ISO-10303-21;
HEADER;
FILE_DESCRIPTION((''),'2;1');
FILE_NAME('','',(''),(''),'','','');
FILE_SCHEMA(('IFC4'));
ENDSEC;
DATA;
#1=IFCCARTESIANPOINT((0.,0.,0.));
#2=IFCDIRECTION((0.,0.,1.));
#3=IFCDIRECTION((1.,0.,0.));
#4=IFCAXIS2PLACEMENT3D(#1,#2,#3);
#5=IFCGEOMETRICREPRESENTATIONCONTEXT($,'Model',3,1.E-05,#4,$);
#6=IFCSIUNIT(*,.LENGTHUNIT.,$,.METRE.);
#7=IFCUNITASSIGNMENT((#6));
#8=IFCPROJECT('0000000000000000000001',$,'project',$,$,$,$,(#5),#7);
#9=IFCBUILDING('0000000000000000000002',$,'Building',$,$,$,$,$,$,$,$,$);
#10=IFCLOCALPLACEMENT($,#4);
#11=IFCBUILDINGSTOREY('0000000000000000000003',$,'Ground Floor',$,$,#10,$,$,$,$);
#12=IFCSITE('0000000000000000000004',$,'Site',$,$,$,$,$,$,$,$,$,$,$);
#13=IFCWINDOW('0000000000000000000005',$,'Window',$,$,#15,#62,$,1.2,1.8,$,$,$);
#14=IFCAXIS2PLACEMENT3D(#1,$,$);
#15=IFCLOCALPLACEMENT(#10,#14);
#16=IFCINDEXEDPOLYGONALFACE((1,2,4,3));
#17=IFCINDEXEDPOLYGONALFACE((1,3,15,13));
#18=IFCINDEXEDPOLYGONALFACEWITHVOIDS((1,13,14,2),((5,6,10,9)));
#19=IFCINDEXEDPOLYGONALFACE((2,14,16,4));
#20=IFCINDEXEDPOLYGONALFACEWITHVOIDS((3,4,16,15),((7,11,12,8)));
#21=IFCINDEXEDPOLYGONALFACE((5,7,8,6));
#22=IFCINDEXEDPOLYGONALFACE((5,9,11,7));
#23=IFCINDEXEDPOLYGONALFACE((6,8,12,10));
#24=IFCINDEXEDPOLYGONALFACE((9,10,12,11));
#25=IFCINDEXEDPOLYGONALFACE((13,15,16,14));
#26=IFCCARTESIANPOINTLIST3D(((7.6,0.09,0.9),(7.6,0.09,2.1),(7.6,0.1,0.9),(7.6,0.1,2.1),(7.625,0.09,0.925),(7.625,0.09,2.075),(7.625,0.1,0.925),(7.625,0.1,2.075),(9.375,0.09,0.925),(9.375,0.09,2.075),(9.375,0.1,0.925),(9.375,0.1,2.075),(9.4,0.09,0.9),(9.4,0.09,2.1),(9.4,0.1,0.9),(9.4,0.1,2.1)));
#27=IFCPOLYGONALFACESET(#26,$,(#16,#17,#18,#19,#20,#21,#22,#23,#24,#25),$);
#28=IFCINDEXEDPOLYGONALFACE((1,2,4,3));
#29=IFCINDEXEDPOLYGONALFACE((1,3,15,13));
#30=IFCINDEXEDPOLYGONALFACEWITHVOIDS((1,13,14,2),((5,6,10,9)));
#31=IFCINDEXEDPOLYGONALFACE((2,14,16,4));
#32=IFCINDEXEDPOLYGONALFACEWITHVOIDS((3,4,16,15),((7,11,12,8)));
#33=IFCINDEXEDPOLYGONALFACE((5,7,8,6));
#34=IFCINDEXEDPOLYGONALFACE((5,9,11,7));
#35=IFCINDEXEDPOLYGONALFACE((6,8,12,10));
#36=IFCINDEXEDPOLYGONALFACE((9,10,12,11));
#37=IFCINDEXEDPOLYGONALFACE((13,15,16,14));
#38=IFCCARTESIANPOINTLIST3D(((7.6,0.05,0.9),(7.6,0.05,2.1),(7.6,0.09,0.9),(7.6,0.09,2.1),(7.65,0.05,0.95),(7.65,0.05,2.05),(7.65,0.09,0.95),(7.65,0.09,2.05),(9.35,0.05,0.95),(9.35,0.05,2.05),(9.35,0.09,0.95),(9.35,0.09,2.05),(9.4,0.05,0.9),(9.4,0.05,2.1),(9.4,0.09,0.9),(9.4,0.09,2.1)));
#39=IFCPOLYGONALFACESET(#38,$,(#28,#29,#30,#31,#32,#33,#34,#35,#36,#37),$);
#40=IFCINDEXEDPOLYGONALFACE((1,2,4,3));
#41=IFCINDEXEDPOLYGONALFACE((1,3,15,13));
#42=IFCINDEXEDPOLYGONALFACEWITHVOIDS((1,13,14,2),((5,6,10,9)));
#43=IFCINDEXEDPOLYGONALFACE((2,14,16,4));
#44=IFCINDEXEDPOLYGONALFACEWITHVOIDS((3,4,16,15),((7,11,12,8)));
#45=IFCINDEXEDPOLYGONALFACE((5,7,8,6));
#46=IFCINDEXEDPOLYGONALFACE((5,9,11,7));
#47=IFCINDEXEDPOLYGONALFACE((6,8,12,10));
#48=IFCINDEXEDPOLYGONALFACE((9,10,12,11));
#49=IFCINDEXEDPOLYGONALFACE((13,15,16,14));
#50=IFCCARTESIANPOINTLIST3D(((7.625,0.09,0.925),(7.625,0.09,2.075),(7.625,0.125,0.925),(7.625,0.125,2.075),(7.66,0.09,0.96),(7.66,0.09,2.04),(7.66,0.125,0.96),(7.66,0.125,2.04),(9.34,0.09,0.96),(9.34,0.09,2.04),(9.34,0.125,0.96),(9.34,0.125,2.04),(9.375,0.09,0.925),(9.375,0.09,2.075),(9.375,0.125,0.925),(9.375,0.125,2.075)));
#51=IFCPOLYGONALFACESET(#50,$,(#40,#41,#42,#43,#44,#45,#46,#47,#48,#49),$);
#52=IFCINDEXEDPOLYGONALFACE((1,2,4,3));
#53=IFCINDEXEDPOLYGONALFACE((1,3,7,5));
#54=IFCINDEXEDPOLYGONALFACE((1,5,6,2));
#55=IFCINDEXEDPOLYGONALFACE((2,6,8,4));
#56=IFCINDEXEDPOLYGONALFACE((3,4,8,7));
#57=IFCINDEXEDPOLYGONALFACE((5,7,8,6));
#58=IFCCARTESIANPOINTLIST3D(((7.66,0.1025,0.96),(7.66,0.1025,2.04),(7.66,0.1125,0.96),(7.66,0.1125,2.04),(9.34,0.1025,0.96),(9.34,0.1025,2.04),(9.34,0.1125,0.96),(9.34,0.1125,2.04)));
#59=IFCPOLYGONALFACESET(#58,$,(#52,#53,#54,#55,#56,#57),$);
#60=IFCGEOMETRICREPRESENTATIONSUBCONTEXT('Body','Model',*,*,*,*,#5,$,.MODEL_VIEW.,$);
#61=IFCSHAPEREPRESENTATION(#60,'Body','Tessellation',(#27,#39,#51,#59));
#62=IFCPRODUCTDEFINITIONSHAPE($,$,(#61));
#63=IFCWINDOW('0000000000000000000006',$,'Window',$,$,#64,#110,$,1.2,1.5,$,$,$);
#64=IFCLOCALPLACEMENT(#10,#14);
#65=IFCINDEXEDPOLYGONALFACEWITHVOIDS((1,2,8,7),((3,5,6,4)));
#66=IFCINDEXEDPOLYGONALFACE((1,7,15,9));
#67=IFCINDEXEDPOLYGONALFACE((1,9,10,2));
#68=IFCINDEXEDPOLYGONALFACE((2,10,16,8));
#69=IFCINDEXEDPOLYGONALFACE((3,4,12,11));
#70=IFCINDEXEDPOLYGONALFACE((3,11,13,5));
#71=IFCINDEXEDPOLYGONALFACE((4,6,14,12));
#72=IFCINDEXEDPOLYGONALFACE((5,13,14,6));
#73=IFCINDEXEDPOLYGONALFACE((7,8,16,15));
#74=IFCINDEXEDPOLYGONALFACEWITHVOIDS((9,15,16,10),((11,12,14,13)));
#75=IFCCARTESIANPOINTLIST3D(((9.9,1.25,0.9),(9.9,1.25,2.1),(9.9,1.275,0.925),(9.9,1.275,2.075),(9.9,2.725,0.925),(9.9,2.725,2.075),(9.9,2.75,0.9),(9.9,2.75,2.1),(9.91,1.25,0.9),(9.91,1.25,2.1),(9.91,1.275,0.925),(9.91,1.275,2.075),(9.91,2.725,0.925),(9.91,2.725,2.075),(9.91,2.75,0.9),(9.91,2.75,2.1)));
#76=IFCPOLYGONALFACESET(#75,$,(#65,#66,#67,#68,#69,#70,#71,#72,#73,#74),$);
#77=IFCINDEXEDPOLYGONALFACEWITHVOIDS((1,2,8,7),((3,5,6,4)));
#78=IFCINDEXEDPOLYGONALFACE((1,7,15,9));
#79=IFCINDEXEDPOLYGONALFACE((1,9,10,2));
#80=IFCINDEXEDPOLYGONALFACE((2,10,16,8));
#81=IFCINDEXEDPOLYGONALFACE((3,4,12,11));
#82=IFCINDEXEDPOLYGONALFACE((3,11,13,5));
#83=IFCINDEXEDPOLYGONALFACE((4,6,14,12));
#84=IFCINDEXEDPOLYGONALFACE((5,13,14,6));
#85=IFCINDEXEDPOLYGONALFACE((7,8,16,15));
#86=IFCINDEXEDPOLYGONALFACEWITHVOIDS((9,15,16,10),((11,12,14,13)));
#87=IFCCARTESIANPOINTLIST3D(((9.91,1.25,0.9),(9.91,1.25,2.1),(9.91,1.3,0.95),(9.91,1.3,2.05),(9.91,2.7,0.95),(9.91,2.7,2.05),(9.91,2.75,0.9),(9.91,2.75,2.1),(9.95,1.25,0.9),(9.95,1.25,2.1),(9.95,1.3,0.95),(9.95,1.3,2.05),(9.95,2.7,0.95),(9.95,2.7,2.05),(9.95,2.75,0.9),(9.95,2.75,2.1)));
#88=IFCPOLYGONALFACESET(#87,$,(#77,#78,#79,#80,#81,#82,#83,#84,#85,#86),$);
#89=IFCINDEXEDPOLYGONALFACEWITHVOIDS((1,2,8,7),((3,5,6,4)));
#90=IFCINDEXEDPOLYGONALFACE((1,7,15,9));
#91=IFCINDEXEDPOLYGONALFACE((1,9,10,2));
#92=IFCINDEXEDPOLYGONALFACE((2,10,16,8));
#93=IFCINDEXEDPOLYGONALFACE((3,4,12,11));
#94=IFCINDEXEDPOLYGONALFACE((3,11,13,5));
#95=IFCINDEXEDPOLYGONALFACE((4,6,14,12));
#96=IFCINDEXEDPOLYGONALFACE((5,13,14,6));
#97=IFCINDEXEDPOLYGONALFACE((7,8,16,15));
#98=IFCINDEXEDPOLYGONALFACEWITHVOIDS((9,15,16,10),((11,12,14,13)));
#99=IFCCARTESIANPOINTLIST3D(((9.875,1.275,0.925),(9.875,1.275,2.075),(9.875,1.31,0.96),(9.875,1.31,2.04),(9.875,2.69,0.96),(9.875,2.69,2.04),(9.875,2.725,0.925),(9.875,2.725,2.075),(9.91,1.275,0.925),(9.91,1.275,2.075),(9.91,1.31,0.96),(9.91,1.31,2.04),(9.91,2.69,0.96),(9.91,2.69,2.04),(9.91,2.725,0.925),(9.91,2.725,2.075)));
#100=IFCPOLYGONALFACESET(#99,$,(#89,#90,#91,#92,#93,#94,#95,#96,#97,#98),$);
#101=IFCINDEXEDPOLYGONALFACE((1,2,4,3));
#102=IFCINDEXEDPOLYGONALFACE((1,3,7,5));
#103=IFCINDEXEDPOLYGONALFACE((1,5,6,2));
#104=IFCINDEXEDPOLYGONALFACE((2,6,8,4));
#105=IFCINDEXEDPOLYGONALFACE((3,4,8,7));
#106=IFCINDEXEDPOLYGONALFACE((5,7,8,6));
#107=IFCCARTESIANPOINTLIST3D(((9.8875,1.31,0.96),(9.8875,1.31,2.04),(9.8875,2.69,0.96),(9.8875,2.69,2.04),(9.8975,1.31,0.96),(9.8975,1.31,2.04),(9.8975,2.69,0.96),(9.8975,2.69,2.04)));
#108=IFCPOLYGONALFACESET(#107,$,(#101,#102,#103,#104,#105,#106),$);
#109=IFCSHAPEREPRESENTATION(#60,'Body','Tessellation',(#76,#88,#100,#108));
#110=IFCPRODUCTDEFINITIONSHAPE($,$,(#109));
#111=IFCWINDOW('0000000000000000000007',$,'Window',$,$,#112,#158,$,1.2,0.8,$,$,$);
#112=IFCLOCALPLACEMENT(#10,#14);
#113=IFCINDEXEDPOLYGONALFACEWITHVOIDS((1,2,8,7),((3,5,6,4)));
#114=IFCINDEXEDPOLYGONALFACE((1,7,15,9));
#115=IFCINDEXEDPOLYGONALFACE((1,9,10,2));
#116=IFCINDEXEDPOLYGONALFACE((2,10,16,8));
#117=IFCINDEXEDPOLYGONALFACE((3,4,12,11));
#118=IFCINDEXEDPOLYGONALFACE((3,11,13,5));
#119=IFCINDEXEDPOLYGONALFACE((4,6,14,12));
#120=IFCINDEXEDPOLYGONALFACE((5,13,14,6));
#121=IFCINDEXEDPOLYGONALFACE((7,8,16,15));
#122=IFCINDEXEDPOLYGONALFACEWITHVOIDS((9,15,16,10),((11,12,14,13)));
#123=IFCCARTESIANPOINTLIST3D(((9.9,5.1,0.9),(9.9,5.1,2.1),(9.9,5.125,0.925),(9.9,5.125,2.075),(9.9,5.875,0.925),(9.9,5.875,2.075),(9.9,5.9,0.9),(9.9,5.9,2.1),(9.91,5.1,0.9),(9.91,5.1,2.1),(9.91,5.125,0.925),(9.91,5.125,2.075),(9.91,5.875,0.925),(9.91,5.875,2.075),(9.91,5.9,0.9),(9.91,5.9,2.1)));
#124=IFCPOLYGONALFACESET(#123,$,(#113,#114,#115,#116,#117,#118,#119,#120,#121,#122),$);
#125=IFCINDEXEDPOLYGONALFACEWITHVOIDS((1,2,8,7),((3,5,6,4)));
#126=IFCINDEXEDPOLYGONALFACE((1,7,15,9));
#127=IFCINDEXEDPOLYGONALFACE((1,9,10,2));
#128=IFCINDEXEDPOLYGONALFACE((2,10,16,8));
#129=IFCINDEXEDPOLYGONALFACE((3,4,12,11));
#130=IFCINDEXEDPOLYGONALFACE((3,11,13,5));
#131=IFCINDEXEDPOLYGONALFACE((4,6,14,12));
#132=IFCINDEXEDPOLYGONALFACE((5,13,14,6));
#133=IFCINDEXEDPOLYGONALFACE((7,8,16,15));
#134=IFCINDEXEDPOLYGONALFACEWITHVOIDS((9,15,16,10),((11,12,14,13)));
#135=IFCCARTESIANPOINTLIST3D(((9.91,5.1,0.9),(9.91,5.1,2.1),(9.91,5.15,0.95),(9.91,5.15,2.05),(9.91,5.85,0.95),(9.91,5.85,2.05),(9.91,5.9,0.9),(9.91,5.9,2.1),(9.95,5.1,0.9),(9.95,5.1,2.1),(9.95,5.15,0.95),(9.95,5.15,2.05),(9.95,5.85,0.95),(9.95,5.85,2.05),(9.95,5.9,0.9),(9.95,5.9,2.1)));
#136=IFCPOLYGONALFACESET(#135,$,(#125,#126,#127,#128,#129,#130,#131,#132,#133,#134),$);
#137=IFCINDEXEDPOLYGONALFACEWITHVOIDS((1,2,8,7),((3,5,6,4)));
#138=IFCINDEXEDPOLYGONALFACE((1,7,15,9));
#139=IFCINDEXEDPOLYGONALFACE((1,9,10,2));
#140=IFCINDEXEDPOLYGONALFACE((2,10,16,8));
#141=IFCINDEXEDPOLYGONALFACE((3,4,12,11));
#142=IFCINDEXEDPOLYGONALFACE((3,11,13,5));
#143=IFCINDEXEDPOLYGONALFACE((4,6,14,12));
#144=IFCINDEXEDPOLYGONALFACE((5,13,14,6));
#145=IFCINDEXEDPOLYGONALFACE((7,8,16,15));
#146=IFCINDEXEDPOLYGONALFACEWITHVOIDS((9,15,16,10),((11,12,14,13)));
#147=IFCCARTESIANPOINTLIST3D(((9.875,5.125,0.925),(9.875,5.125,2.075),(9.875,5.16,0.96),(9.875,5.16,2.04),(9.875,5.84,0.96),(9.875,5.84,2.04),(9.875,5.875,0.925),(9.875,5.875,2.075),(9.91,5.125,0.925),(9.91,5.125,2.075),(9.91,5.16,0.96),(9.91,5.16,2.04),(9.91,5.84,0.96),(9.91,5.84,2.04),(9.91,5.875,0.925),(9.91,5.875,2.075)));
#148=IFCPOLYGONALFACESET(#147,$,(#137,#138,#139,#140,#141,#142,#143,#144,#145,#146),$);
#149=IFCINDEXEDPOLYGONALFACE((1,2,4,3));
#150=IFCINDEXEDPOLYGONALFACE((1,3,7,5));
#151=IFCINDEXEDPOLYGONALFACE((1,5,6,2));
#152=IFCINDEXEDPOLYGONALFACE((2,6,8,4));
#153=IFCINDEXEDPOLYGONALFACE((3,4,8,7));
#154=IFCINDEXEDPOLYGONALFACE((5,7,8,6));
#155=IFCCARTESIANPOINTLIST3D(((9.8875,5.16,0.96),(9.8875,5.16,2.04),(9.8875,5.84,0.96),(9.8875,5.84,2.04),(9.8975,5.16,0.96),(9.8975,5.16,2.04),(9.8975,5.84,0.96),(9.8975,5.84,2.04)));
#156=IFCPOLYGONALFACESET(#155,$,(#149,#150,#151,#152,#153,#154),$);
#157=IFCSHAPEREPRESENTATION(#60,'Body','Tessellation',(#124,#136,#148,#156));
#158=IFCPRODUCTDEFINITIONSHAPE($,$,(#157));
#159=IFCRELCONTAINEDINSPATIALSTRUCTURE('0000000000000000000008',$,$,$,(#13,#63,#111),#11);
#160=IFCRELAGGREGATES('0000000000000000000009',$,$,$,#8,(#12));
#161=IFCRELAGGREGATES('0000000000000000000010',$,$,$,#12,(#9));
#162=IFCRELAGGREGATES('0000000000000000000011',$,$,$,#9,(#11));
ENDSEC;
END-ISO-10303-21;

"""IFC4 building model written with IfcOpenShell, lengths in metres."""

from ifc_helpers import new_model, si_unit, frame, origin_with_axes, place, context, subcontext, project, spatial, line, indexed_curve, outline, extrude, element, save


model = new_model("IFC4")

# Units and contexts
model_context = context("Model", 3, precision=1e-05, world=origin_with_axes())
body_context = subcontext(model_context, "Body", "Model", "MODEL_VIEW")
ifc_project = project(units=[si_unit("LENGTHUNIT", "METRE")], contexts=[model_context])

# Site, building, storey
site = spatial("IfcSite", under=ifc_project, Name="Site")
building = spatial("IfcBuilding", under=site, Name="Building")
storey_placement = place(None, origin_with_axes())
storey = spatial("IfcBuildingStorey", under=building, at=storey_placement, Name="Ground Floor")

# Windows
window_1_placement = place(storey_placement, frame((7.6, 0.0, 0.9), z_axis=(0.0, 0.0, 1.0), x_axis=(1.0, 0.0, 0.0)))
element("IfcWindow", 1, at=window_1_placement, inside=storey, Name="Window", OverallHeight=1.2, OverallWidth=1.8, context=body_context, shape_type="SweptSolid", body=[
    extrude(outline(indexed_curve([(0.0, 0.0), (1.8, 0.0), (1.8, 1.2), (0.0, 1.2)], segments=[line(1, 2, 3, 4, 1)]), holes=[indexed_curve([(0.025, 0.025), (1.775, 0.025), (1.775, 1.175), (0.025, 1.175)], segments=[line(1, 2, 3, 4, 1)])]), frame((0.0, 0.09, 0.0), z_axis=(0.0, -1.0, 0.0), x_axis=(1.0, 0.0, 0.0)), (0.0, 0.0, -1.0), 0.01),
    extrude(outline(indexed_curve([(0.0, 0.0), (1.8, 0.0), (1.8, 1.2), (0.0, 1.2)], segments=[line(1, 2, 3, 4, 1)]), holes=[indexed_curve([(0.05, 0.05), (1.75, 0.05), (1.75, 1.15), (0.05, 1.15)], segments=[line(1, 2, 3, 4, 1)])]), frame((0.0, 0.05, 0.0), z_axis=(0.0, -1.0, 0.0), x_axis=(1.0, 0.0, 0.0)), (0.0, 0.0, -1.0), 0.04),
    extrude(outline(indexed_curve([(0.0, 0.0), (1.75, 0.0), (1.75, 1.15), (0.0, 1.15)], segments=[line(1, 2, 3, 4, 1)]), holes=[indexed_curve([(0.035, 0.035), (1.715, 0.035), (1.715, 1.115), (0.035, 1.115)], segments=[line(1, 2, 3, 4, 1)])]), frame((0.025, 0.09, 0.025), z_axis=(0.0, -1.0, 0.0), x_axis=(1.0, 0.0, 0.0)), (0.0, 0.0, -1.0), 0.035),
    extrude(outline(indexed_curve([(0.035, 0.035), (1.715, 0.035), (1.715, 1.115), (0.035, 1.115)], segments=[line(1, 2, 3, 4, 1)])), frame((0.025, 0.1025, 0.025), z_axis=(0.0, -1.0, 0.0), x_axis=(1.0, 0.0, 0.0)), (0.0, 0.0, -1.0), 0.01),
])
window_2_placement = place(storey_placement, frame((10.0, 1.25, 0.9), z_axis=(0.0, 0.0, 1.0), x_axis=(0.0, 1.0, 0.0)))
element("IfcWindow", 2, at=window_2_placement, inside=storey, Name="Window", OverallHeight=1.2, OverallWidth=1.5, context=body_context, shape_type="SweptSolid", body=[
    extrude(outline(indexed_curve([(0.0, 0.0), (1.5, 0.0), (1.5, 1.2), (0.0, 1.2)], segments=[line(1, 2, 3, 4, 1)]), holes=[indexed_curve([(0.025, 0.025), (1.475, 0.025), (1.475, 1.175), (0.025, 1.175)], segments=[line(1, 2, 3, 4, 1)])]), frame((0.0, 0.09, 0.0), z_axis=(0.0, -1.0, 0.0), x_axis=(1.0, 0.0, 0.0)), (0.0, 0.0, -1.0), 0.01),
    extrude(outline(indexed_curve([(0.0, 0.0), (1.5, 0.0), (1.5, 1.2), (0.0, 1.2)], segments=[line(1, 2, 3, 4, 1)]), holes=[indexed_curve([(0.05, 0.05), (1.45, 0.05), (1.45, 1.15), (0.05, 1.15)], segments=[line(1, 2, 3, 4, 1)])]), frame((0.0, 0.05, 0.0), z_axis=(0.0, -1.0, 0.0), x_axis=(1.0, 0.0, 0.0)), (0.0, 0.0, -1.0), 0.04),
    extrude(outline(indexed_curve([(0.0, 0.0), (1.45, 0.0), (1.45, 1.15), (0.0, 1.15)], segments=[line(1, 2, 3, 4, 1)]), holes=[indexed_curve([(0.035, 0.035), (1.415, 0.035), (1.415, 1.115), (0.035, 1.115)], segments=[line(1, 2, 3, 4, 1)])]), frame((0.025, 0.09, 0.025), z_axis=(0.0, -1.0, 0.0), x_axis=(1.0, 0.0, 0.0)), (0.0, 0.0, -1.0), 0.035),
    extrude(outline(indexed_curve([(0.035, 0.035), (1.415, 0.035), (1.415, 1.115), (0.035, 1.115)], segments=[line(1, 2, 3, 4, 1)])), frame((0.025, 0.1025, 0.025), z_axis=(0.0, -1.0, 0.0), x_axis=(1.0, 0.0, 0.0)), (0.0, 0.0, -1.0), 0.01),
])
window_3_placement = place(storey_placement, frame((10.0, 5.1, 0.9), z_axis=(0.0, 0.0, 1.0), x_axis=(0.0, 1.0, 0.0)))
element("IfcWindow", 3, at=window_3_placement, inside=storey, Name="Window", OverallHeight=1.2, OverallWidth=0.8, context=body_context, shape_type="SweptSolid", body=[
    extrude(outline(indexed_curve([(0.0, 0.0), (0.8, 0.0), (0.8, 1.2), (0.0, 1.2)], segments=[line(1, 2, 3, 4, 1)]), holes=[indexed_curve([(0.025, 0.025), (0.775, 0.025), (0.775, 1.175), (0.025, 1.175)], segments=[line(1, 2, 3, 4, 1)])]), frame((0.0, 0.09, 0.0), z_axis=(0.0, -1.0, 0.0), x_axis=(1.0, 0.0, 0.0)), (0.0, 0.0, -1.0), 0.01),
    extrude(outline(indexed_curve([(0.0, 0.0), (0.8, 0.0), (0.8, 1.2), (0.0, 1.2)], segments=[line(1, 2, 3, 4, 1)]), holes=[indexed_curve([(0.05, 0.05), (0.75, 0.05), (0.75, 1.15), (0.05, 1.15)], segments=[line(1, 2, 3, 4, 1)])]), frame((0.0, 0.05, 0.0), z_axis=(0.0, -1.0, 0.0), x_axis=(1.0, 0.0, 0.0)), (0.0, 0.0, -1.0), 0.04),
    extrude(outline(indexed_curve([(0.0, 0.0), (0.75, 0.0), (0.75, 1.15), (0.0, 1.15)], segments=[line(1, 2, 3, 4, 1)]), holes=[indexed_curve([(0.035, 0.035), (0.715, 0.035), (0.715, 1.115), (0.035, 1.115)], segments=[line(1, 2, 3, 4, 1)])]), frame((0.025, 0.09, 0.025), z_axis=(0.0, -1.0, 0.0), x_axis=(1.0, 0.0, 0.0)), (0.0, 0.0, -1.0), 0.035),
    extrude(outline(indexed_curve([(0.035, 0.035), (0.715, 0.035), (0.715, 1.115), (0.035, 1.115)], segments=[line(1, 2, 3, 4, 1)])), frame((0.025, 0.1025, 0.025), z_axis=(0.0, -1.0, 0.0), x_axis=(1.0, 0.0, 0.0)), (0.0, 0.0, -1.0), 0.01),
])

save(model, "model.ifc")
